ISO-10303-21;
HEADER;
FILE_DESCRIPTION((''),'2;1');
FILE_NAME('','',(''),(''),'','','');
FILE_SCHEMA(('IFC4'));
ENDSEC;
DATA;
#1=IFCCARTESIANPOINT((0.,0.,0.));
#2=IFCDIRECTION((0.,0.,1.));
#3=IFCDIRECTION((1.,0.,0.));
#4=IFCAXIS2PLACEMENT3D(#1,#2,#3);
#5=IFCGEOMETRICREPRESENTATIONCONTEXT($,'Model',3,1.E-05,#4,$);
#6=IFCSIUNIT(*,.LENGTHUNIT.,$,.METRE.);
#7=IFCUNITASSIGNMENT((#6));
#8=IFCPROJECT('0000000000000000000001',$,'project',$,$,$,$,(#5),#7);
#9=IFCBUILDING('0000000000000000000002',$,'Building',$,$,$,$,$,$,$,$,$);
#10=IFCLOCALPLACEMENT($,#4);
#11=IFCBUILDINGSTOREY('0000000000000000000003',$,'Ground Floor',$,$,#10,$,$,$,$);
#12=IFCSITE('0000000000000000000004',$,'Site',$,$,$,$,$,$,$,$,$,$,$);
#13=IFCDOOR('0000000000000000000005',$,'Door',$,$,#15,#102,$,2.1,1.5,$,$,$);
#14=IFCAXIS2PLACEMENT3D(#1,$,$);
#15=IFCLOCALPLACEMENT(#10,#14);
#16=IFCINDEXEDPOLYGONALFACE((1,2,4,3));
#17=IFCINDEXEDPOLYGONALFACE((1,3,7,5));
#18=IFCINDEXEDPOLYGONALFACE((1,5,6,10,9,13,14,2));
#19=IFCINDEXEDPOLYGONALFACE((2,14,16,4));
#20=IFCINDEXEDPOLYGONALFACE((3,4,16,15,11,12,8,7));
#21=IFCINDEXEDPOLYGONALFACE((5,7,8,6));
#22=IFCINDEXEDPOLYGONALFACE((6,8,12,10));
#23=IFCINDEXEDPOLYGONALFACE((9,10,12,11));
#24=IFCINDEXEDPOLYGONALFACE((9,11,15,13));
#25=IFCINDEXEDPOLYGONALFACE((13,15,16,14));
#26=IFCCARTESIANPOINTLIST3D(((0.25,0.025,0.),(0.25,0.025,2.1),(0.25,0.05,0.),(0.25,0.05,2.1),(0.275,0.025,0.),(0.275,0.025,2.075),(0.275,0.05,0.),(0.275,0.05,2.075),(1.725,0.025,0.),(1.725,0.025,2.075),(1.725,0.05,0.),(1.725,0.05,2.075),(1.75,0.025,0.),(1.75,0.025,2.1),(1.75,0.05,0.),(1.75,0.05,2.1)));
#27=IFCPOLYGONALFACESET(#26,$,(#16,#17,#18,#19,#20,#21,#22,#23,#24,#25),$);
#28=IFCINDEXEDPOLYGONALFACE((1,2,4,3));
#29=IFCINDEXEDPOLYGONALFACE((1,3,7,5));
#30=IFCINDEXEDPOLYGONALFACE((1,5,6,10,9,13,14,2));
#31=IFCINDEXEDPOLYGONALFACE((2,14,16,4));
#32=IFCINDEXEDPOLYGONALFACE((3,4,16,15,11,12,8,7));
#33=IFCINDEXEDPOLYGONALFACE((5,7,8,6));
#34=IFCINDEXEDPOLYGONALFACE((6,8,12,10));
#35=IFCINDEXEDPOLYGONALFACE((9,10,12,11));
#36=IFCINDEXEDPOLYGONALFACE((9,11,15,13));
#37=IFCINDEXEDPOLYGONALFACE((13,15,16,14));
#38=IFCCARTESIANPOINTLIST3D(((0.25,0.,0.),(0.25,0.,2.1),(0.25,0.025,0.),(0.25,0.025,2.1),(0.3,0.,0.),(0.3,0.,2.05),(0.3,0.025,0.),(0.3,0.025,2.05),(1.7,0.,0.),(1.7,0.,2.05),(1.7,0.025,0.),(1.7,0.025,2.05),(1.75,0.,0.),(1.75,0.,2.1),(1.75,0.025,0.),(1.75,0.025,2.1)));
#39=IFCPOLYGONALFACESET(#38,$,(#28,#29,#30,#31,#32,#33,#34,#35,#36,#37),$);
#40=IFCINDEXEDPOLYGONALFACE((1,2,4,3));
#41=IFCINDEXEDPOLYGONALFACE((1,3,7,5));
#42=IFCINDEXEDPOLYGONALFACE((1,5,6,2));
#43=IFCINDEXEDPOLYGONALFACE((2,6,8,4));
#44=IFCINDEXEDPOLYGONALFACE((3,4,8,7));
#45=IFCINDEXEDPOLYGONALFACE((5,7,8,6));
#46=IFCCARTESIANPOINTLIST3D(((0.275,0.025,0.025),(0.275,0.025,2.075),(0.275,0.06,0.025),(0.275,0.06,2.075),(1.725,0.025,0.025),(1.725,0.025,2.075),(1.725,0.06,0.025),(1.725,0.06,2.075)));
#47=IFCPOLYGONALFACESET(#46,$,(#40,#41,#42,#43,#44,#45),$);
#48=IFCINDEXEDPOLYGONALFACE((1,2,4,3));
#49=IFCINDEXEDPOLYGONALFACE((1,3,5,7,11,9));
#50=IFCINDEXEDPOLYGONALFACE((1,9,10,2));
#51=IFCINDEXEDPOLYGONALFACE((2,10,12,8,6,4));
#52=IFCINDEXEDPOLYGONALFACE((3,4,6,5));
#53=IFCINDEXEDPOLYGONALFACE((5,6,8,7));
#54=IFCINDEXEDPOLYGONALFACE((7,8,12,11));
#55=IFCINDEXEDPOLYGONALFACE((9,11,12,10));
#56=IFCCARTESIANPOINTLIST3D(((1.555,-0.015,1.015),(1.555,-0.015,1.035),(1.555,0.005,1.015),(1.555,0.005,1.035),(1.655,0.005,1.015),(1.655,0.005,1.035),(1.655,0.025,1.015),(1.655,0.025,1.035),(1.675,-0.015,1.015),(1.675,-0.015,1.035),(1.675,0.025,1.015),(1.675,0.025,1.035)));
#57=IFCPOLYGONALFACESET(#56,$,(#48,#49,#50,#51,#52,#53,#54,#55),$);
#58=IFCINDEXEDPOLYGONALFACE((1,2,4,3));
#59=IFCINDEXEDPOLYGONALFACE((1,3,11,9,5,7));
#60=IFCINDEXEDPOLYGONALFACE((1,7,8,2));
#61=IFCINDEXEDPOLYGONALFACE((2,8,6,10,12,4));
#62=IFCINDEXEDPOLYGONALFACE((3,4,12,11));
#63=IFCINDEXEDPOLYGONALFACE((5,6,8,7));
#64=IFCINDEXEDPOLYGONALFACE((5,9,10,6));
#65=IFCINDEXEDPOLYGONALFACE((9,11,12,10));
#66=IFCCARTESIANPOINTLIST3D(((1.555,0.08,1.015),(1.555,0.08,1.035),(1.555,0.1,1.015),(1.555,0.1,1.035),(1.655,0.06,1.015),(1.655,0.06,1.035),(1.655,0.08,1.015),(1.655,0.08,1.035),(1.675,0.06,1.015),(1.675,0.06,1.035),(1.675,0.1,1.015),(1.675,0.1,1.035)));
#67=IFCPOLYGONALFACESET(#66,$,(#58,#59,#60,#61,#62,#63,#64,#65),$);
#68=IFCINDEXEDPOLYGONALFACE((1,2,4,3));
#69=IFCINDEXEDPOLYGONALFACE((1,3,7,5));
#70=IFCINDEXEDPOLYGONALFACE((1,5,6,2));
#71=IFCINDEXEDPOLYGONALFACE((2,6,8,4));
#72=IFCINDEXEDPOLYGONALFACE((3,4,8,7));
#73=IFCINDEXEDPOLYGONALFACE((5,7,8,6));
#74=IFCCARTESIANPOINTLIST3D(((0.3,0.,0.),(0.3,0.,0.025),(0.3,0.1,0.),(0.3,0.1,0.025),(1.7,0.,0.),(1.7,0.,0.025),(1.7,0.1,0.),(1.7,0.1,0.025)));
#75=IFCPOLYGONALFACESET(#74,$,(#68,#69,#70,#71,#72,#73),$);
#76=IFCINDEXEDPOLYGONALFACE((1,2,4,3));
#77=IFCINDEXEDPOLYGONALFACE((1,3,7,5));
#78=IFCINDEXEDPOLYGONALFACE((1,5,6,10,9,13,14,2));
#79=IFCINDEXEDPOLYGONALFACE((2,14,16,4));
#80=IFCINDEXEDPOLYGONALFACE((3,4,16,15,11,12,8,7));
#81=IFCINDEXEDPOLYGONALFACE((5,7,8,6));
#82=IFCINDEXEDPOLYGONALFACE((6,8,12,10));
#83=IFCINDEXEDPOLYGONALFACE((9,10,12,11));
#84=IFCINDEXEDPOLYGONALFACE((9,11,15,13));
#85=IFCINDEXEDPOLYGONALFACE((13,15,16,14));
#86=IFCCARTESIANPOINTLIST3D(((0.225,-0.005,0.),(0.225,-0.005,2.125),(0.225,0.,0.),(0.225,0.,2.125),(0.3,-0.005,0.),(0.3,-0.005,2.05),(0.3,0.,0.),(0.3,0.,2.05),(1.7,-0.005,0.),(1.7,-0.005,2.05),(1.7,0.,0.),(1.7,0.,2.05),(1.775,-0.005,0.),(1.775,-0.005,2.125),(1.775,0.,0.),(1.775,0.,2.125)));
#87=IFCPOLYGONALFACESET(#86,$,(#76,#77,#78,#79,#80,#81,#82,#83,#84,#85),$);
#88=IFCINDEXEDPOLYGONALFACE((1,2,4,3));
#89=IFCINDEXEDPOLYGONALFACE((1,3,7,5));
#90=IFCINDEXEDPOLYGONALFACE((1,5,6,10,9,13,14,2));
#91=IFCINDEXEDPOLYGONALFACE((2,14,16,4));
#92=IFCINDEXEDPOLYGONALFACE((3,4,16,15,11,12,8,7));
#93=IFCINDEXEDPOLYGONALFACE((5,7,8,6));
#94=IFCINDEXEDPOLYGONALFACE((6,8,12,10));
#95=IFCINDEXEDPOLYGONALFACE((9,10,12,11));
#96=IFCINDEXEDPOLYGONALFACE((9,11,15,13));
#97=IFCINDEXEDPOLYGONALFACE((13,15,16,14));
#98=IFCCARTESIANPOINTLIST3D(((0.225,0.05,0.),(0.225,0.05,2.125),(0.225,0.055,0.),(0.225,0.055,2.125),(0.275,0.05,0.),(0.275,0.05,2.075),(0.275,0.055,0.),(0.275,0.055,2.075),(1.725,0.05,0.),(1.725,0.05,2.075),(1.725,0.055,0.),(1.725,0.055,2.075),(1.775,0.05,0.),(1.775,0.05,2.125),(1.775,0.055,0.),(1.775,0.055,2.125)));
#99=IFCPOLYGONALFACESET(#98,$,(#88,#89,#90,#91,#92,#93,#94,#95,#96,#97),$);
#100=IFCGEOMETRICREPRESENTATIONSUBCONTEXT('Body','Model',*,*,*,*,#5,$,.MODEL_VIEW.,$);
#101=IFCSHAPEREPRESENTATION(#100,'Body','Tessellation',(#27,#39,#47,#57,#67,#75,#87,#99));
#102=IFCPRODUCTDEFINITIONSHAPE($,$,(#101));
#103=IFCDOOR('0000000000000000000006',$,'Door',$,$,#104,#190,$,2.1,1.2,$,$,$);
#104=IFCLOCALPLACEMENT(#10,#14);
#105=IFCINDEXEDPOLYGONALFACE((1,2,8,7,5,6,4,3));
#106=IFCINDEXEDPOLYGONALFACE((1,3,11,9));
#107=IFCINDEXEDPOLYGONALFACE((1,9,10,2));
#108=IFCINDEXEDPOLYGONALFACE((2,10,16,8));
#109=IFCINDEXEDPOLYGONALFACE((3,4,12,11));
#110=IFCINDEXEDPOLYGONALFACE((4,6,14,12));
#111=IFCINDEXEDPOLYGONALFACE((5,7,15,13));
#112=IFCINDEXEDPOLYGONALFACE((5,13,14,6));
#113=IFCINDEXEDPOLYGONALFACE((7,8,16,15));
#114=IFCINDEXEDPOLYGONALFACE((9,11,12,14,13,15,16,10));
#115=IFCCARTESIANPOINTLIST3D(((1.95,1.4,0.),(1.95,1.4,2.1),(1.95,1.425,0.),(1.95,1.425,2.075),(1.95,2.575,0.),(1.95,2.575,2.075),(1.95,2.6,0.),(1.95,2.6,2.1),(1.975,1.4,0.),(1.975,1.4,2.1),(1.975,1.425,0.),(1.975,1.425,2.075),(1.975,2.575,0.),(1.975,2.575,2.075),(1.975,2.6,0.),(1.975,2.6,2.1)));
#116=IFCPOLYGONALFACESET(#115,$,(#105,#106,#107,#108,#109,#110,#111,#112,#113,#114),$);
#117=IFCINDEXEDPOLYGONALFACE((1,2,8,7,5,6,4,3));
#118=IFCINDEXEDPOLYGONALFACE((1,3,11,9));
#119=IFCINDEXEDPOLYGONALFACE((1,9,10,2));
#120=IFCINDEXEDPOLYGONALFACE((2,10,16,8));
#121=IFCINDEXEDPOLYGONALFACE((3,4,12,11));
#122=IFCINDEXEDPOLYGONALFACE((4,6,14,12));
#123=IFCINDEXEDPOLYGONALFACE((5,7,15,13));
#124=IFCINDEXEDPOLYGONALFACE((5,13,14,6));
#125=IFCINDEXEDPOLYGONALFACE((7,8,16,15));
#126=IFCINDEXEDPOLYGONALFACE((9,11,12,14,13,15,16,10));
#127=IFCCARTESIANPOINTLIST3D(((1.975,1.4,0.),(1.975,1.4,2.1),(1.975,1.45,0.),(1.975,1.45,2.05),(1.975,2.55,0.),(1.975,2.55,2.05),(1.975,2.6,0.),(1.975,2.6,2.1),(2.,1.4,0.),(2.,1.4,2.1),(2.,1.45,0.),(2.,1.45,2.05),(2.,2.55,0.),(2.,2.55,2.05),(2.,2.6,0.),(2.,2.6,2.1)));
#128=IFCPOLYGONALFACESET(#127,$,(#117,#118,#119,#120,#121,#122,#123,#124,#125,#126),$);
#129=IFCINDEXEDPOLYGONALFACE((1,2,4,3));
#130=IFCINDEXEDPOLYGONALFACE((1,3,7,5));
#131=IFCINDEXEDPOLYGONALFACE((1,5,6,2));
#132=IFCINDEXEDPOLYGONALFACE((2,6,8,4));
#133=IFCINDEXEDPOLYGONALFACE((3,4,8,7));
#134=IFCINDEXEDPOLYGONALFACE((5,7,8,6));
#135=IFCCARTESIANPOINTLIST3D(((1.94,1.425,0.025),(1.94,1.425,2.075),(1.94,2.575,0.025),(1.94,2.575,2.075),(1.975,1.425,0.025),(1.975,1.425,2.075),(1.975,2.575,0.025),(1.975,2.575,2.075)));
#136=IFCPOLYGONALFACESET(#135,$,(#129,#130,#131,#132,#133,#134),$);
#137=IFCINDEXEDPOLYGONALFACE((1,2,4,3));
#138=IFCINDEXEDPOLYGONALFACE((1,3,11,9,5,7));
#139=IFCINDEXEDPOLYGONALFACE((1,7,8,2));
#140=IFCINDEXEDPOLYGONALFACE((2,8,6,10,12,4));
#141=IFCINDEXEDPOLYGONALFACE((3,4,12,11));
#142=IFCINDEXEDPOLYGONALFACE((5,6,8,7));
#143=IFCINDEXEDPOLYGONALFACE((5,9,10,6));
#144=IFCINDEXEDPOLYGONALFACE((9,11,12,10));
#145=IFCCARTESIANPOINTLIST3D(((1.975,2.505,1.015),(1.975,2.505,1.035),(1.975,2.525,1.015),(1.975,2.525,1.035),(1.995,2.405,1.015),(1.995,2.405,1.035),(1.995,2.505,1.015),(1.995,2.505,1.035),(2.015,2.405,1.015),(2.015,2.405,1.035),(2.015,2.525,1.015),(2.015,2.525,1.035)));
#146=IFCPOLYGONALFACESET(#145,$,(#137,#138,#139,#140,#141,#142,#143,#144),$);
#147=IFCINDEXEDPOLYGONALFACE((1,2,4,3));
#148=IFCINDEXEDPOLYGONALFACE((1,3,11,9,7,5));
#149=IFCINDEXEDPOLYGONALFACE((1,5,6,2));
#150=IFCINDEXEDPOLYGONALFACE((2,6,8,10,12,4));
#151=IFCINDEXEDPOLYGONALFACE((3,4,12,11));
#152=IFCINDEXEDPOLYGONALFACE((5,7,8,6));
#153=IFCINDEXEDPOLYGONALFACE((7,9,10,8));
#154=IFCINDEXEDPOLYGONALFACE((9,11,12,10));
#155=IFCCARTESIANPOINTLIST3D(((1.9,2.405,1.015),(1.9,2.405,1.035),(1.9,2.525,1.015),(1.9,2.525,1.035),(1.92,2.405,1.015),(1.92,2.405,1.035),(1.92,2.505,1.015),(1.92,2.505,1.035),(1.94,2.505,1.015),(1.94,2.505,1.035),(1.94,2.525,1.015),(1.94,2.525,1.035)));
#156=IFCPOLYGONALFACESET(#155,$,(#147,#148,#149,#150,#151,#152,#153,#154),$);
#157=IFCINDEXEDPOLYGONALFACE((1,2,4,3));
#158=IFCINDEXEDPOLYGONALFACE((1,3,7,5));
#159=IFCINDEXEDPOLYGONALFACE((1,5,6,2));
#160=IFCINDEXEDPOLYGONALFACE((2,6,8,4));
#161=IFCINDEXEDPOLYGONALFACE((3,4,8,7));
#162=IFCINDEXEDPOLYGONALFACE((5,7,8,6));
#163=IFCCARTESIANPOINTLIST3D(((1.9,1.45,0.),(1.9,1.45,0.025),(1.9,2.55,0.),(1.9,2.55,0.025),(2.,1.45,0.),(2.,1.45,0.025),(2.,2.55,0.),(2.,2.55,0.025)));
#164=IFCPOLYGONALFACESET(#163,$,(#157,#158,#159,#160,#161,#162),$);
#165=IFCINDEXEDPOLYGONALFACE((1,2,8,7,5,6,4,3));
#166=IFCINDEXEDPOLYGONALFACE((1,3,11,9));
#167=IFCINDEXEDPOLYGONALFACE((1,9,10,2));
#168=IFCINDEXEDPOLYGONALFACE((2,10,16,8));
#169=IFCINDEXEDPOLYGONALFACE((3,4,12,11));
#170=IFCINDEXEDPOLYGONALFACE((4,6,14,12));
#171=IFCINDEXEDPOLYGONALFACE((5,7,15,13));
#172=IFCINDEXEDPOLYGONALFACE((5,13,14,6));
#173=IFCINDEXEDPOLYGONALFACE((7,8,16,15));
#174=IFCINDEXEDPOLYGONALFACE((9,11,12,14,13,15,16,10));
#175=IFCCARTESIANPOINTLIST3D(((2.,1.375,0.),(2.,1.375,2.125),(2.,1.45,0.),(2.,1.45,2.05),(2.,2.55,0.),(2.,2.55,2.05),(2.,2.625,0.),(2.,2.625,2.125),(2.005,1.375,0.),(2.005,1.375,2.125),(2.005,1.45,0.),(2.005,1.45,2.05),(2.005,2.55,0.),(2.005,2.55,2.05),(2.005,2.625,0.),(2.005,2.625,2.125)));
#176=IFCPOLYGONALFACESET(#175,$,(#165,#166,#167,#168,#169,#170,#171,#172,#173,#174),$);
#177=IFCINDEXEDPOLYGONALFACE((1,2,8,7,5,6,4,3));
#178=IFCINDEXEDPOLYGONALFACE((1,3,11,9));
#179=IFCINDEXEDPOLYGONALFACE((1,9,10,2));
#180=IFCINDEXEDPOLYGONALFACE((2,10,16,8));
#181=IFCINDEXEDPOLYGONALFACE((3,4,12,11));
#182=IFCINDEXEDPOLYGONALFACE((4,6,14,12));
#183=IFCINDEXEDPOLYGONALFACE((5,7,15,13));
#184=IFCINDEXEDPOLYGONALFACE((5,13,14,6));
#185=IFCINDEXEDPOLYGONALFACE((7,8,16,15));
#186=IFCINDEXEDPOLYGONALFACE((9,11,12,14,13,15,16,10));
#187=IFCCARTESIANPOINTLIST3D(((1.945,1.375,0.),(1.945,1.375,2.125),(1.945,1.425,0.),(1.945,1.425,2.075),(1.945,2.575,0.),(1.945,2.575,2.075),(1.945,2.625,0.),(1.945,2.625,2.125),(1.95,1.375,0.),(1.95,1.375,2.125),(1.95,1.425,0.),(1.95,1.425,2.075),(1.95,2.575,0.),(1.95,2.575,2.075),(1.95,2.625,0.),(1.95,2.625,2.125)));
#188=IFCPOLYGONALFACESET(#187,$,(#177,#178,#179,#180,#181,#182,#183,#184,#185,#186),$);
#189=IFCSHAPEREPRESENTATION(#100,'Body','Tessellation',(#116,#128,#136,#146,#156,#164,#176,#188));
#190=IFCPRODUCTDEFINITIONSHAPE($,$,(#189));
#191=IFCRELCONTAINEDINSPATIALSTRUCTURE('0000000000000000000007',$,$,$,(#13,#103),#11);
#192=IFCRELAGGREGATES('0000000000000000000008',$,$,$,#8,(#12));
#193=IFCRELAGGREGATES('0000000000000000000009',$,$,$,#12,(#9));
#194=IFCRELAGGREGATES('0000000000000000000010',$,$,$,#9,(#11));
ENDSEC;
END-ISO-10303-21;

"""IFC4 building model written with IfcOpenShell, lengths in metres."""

from ifc_helpers import new_model, si_unit, frame, origin_with_axes, place, context, subcontext, project, spatial, line, indexed_curve, outline, extrude, element, save


model = new_model("IFC4")

# Units and contexts
model_context = context("Model", 3, precision=1e-05, world=origin_with_axes())
body_context = subcontext(model_context, "Body", "Model", "MODEL_VIEW")
ifc_project = project(units=[si_unit("LENGTHUNIT", "METRE")], contexts=[model_context])

# Site, building, storey
site = spatial("IfcSite", under=ifc_project, Name="Site")
building = spatial("IfcBuilding", under=site, Name="Building")
storey_placement = place(None, origin_with_axes())
storey = spatial("IfcBuildingStorey", under=building, at=storey_placement, Name="Ground Floor")

# Doors
door_1_placement = place(storey_placement, frame((0.25, 0.0, 0.0), z_axis=(0.0, 0.0, 1.0), x_axis=(1.0, 0.0, 0.0)))
element("IfcDoor", 1, at=door_1_placement, inside=storey, Name="Door", OverallHeight=2.1, OverallWidth=1.5, context=body_context, shape_type="SweptSolid", body=[
    extrude(outline(indexed_curve([(0.0, 0.0), (0.0, 2.1), (1.5, 2.1), (1.5, 0.0), (1.475, 0.0), (1.475, 2.075), (0.025, 2.075), (0.025, 0.0)], segments=[line(1, 2, 3, 4, 5, 6, 7, 8, 1)])), frame((0.0, 0.025, 0.0), z_axis=(0.0, -1.0, 0.0), x_axis=(1.0, 0.0, 0.0)), (0.0, 0.0, -1.0), 0.025),
    extrude(outline(indexed_curve([(0.0, 0.0), (0.0, 2.1), (1.5, 2.1), (1.5, 0.0), (1.45, 0.0), (1.45, 2.05), (0.05, 2.05), (0.05, 0.0)], segments=[line(1, 2, 3, 4, 5, 6, 7, 8, 1)])), frame((0.0, 0.0, 0.0), z_axis=(0.0, -1.0, 0.0), x_axis=(1.0, 0.0, 0.0)), (0.0, 0.0, -1.0), 0.025),
    extrude(outline(indexed_curve([(0.0, 0.0), (1.45, 0.0), (1.45, 0.035), (0.0, 0.035)], segments=[line(1, 2, 3, 4, 1)])), frame((0.025, 0.025, 0.025), z_axis=(0.0, 0.0, 1.0), x_axis=(1.0, 0.0, 0.0)), (0.0, 0.0, 1.0), 2.05),
    extrude(outline(indexed_curve([(0.0, 0.0), (0.0, -0.04), (-0.12, -0.04), (-0.12, -0.02), (-0.02, -0.02), (-0.02, 0.0)], segments=[line(1, 2, 3, 4, 5, 6, 1)])), frame((1.425, 0.025, 1.015), z_axis=(0.0, 0.0, 1.0), x_axis=(1.0, 0.0, 0.0)), (0.0, 0.0, 1.0), 0.02),
    extrude(outline(indexed_curve([(0.0, 0.0), (0.0, 0.04), (-0.12, 0.04), (-0.12, 0.02), (-0.02, 0.02), (-0.02, 0.0)], segments=[line(1, 2, 3, 4, 5, 6, 1)])), frame((1.425, 0.06, 1.015), z_axis=(0.0, 0.0, 1.0), x_axis=(1.0, 0.0, 0.0)), (0.0, 0.0, 1.0), 0.02),
    extrude(outline(indexed_curve([(0.0, 0.0), (1.4, 0.0), (1.4, 0.1), (0.0, 0.1)], segments=[line(1, 2, 3, 4, 1)])), frame((0.05, 0.0, 0.0), z_axis=(0.0, 0.0, 1.0), x_axis=(1.0, 0.0, 0.0)), (0.0, 0.0, 1.0), 0.025),
    extrude(outline(indexed_curve([(0.0, 0.0), (0.0, 2.125), (1.55, 2.125), (1.55, 0.0), (1.475, 0.0), (1.475, 2.05), (0.075, 2.05), (0.075, 0.0)], segments=[line(1, 2, 3, 4, 5, 6, 7, 8, 1)])), frame((-0.025, -0.005, 0.0), z_axis=(0.0, -1.0, 0.0), x_axis=(1.0, 0.0, 0.0)), (0.0, 0.0, -1.0), 0.005),
    extrude(outline(indexed_curve([(0.0, 0.0), (0.0, 2.125), (1.55, 2.125), (1.55, 0.0), (1.5, 0.0), (1.5, 2.075), (0.05, 2.075), (0.05, 0.0)], segments=[line(1, 2, 3, 4, 5, 6, 7, 8, 1)])), frame((-0.025, 0.05, 0.0), z_axis=(0.0, -1.0, 0.0), x_axis=(1.0, 0.0, 0.0)), (0.0, 0.0, -1.0), 0.005),
])
door_2_placement = place(storey_placement, frame((2.0, 1.4, 0.0), z_axis=(0.0, 0.0, 1.0), x_axis=(0.0, 1.0, 0.0)))
element("IfcDoor", 2, at=door_2_placement, inside=storey, Name="Door", OverallHeight=2.1, OverallWidth=1.2, context=body_context, shape_type="SweptSolid", body=[
    extrude(outline(indexed_curve([(0.0, 0.0), (0.0, 2.1), (1.2, 2.1), (1.2, 0.0), (1.175, 0.0), (1.175, 2.075), (0.025, 2.075), (0.025, 0.0)], segments=[line(1, 2, 3, 4, 5, 6, 7, 8, 1)])), frame((0.0, 0.025, 0.0), z_axis=(0.0, -1.0, 0.0), x_axis=(1.0, 0.0, 0.0)), (0.0, 0.0, -1.0), 0.025),
    extrude(outline(indexed_curve([(0.0, 0.0), (0.0, 2.1), (1.2, 2.1), (1.2, 0.0), (1.15, 0.0), (1.15, 2.05), (0.05, 2.05), (0.05, 0.0)], segments=[line(1, 2, 3, 4, 5, 6, 7, 8, 1)])), frame((0.0, 0.0, 0.0), z_axis=(0.0, -1.0, 0.0), x_axis=(1.0, 0.0, 0.0)), (0.0, 0.0, -1.0), 0.025),
    extrude(outline(indexed_curve([(0.0, 0.0), (1.15, 0.0), (1.15, 0.035), (0.0, 0.035)], segments=[line(1, 2, 3, 4, 1)])), frame((0.025, 0.025, 0.025), z_axis=(0.0, 0.0, 1.0), x_axis=(1.0, 0.0, 0.0)), (0.0, 0.0, 1.0), 2.05),
    extrude(outline(indexed_curve([(0.0, 0.0), (0.0, -0.04), (-0.12, -0.04), (-0.12, -0.02), (-0.02, -0.02), (-0.02, 0.0)], segments=[line(1, 2, 3, 4, 5, 6, 1)])), frame((1.125, 0.025, 1.015), z_axis=(0.0, 0.0, 1.0), x_axis=(1.0, 0.0, 0.0)), (0.0, 0.0, 1.0), 0.02),
    extrude(outline(indexed_curve([(0.0, 0.0), (0.0, 0.04), (-0.12, 0.04), (-0.12, 0.02), (-0.02, 0.02), (-0.02, 0.0)], segments=[line(1, 2, 3, 4, 5, 6, 1)])), frame((1.125, 0.06, 1.015), z_axis=(0.0, 0.0, 1.0), x_axis=(1.0, 0.0, 0.0)), (0.0, 0.0, 1.0), 0.02),
    extrude(outline(indexed_curve([(0.0, 0.0), (1.1, 0.0), (1.1, 0.1), (0.0, 0.1)], segments=[line(1, 2, 3, 4, 1)])), frame((0.05, 0.0, 0.0), z_axis=(0.0, 0.0, 1.0), x_axis=(1.0, 0.0, 0.0)), (0.0, 0.0, 1.0), 0.025),
    extrude(outline(indexed_curve([(0.0, 0.0), (0.0, 2.125), (1.25, 2.125), (1.25, 0.0), (1.175, 0.0), (1.175, 2.05), (0.075, 2.05), (0.075, 0.0)], segments=[line(1, 2, 3, 4, 5, 6, 7, 8, 1)])), frame((-0.025, -0.005, 0.0), z_axis=(0.0, -1.0, 0.0), x_axis=(1.0, 0.0, 0.0)), (0.0, 0.0, -1.0), 0.005),
    extrude(outline(indexed_curve([(0.0, 0.0), (0.0, 2.125), (1.25, 2.125), (1.25, 0.0), (1.2, 0.0), (1.2, 2.075), (0.05, 2.075), (0.05, 0.0)], segments=[line(1, 2, 3, 4, 5, 6, 7, 8, 1)])), frame((-0.025, 0.05, 0.0), z_axis=(0.0, -1.0, 0.0), x_axis=(1.0, 0.0, 0.0)), (0.0, 0.0, -1.0), 0.005),
])

save(model, "model.ifc")
